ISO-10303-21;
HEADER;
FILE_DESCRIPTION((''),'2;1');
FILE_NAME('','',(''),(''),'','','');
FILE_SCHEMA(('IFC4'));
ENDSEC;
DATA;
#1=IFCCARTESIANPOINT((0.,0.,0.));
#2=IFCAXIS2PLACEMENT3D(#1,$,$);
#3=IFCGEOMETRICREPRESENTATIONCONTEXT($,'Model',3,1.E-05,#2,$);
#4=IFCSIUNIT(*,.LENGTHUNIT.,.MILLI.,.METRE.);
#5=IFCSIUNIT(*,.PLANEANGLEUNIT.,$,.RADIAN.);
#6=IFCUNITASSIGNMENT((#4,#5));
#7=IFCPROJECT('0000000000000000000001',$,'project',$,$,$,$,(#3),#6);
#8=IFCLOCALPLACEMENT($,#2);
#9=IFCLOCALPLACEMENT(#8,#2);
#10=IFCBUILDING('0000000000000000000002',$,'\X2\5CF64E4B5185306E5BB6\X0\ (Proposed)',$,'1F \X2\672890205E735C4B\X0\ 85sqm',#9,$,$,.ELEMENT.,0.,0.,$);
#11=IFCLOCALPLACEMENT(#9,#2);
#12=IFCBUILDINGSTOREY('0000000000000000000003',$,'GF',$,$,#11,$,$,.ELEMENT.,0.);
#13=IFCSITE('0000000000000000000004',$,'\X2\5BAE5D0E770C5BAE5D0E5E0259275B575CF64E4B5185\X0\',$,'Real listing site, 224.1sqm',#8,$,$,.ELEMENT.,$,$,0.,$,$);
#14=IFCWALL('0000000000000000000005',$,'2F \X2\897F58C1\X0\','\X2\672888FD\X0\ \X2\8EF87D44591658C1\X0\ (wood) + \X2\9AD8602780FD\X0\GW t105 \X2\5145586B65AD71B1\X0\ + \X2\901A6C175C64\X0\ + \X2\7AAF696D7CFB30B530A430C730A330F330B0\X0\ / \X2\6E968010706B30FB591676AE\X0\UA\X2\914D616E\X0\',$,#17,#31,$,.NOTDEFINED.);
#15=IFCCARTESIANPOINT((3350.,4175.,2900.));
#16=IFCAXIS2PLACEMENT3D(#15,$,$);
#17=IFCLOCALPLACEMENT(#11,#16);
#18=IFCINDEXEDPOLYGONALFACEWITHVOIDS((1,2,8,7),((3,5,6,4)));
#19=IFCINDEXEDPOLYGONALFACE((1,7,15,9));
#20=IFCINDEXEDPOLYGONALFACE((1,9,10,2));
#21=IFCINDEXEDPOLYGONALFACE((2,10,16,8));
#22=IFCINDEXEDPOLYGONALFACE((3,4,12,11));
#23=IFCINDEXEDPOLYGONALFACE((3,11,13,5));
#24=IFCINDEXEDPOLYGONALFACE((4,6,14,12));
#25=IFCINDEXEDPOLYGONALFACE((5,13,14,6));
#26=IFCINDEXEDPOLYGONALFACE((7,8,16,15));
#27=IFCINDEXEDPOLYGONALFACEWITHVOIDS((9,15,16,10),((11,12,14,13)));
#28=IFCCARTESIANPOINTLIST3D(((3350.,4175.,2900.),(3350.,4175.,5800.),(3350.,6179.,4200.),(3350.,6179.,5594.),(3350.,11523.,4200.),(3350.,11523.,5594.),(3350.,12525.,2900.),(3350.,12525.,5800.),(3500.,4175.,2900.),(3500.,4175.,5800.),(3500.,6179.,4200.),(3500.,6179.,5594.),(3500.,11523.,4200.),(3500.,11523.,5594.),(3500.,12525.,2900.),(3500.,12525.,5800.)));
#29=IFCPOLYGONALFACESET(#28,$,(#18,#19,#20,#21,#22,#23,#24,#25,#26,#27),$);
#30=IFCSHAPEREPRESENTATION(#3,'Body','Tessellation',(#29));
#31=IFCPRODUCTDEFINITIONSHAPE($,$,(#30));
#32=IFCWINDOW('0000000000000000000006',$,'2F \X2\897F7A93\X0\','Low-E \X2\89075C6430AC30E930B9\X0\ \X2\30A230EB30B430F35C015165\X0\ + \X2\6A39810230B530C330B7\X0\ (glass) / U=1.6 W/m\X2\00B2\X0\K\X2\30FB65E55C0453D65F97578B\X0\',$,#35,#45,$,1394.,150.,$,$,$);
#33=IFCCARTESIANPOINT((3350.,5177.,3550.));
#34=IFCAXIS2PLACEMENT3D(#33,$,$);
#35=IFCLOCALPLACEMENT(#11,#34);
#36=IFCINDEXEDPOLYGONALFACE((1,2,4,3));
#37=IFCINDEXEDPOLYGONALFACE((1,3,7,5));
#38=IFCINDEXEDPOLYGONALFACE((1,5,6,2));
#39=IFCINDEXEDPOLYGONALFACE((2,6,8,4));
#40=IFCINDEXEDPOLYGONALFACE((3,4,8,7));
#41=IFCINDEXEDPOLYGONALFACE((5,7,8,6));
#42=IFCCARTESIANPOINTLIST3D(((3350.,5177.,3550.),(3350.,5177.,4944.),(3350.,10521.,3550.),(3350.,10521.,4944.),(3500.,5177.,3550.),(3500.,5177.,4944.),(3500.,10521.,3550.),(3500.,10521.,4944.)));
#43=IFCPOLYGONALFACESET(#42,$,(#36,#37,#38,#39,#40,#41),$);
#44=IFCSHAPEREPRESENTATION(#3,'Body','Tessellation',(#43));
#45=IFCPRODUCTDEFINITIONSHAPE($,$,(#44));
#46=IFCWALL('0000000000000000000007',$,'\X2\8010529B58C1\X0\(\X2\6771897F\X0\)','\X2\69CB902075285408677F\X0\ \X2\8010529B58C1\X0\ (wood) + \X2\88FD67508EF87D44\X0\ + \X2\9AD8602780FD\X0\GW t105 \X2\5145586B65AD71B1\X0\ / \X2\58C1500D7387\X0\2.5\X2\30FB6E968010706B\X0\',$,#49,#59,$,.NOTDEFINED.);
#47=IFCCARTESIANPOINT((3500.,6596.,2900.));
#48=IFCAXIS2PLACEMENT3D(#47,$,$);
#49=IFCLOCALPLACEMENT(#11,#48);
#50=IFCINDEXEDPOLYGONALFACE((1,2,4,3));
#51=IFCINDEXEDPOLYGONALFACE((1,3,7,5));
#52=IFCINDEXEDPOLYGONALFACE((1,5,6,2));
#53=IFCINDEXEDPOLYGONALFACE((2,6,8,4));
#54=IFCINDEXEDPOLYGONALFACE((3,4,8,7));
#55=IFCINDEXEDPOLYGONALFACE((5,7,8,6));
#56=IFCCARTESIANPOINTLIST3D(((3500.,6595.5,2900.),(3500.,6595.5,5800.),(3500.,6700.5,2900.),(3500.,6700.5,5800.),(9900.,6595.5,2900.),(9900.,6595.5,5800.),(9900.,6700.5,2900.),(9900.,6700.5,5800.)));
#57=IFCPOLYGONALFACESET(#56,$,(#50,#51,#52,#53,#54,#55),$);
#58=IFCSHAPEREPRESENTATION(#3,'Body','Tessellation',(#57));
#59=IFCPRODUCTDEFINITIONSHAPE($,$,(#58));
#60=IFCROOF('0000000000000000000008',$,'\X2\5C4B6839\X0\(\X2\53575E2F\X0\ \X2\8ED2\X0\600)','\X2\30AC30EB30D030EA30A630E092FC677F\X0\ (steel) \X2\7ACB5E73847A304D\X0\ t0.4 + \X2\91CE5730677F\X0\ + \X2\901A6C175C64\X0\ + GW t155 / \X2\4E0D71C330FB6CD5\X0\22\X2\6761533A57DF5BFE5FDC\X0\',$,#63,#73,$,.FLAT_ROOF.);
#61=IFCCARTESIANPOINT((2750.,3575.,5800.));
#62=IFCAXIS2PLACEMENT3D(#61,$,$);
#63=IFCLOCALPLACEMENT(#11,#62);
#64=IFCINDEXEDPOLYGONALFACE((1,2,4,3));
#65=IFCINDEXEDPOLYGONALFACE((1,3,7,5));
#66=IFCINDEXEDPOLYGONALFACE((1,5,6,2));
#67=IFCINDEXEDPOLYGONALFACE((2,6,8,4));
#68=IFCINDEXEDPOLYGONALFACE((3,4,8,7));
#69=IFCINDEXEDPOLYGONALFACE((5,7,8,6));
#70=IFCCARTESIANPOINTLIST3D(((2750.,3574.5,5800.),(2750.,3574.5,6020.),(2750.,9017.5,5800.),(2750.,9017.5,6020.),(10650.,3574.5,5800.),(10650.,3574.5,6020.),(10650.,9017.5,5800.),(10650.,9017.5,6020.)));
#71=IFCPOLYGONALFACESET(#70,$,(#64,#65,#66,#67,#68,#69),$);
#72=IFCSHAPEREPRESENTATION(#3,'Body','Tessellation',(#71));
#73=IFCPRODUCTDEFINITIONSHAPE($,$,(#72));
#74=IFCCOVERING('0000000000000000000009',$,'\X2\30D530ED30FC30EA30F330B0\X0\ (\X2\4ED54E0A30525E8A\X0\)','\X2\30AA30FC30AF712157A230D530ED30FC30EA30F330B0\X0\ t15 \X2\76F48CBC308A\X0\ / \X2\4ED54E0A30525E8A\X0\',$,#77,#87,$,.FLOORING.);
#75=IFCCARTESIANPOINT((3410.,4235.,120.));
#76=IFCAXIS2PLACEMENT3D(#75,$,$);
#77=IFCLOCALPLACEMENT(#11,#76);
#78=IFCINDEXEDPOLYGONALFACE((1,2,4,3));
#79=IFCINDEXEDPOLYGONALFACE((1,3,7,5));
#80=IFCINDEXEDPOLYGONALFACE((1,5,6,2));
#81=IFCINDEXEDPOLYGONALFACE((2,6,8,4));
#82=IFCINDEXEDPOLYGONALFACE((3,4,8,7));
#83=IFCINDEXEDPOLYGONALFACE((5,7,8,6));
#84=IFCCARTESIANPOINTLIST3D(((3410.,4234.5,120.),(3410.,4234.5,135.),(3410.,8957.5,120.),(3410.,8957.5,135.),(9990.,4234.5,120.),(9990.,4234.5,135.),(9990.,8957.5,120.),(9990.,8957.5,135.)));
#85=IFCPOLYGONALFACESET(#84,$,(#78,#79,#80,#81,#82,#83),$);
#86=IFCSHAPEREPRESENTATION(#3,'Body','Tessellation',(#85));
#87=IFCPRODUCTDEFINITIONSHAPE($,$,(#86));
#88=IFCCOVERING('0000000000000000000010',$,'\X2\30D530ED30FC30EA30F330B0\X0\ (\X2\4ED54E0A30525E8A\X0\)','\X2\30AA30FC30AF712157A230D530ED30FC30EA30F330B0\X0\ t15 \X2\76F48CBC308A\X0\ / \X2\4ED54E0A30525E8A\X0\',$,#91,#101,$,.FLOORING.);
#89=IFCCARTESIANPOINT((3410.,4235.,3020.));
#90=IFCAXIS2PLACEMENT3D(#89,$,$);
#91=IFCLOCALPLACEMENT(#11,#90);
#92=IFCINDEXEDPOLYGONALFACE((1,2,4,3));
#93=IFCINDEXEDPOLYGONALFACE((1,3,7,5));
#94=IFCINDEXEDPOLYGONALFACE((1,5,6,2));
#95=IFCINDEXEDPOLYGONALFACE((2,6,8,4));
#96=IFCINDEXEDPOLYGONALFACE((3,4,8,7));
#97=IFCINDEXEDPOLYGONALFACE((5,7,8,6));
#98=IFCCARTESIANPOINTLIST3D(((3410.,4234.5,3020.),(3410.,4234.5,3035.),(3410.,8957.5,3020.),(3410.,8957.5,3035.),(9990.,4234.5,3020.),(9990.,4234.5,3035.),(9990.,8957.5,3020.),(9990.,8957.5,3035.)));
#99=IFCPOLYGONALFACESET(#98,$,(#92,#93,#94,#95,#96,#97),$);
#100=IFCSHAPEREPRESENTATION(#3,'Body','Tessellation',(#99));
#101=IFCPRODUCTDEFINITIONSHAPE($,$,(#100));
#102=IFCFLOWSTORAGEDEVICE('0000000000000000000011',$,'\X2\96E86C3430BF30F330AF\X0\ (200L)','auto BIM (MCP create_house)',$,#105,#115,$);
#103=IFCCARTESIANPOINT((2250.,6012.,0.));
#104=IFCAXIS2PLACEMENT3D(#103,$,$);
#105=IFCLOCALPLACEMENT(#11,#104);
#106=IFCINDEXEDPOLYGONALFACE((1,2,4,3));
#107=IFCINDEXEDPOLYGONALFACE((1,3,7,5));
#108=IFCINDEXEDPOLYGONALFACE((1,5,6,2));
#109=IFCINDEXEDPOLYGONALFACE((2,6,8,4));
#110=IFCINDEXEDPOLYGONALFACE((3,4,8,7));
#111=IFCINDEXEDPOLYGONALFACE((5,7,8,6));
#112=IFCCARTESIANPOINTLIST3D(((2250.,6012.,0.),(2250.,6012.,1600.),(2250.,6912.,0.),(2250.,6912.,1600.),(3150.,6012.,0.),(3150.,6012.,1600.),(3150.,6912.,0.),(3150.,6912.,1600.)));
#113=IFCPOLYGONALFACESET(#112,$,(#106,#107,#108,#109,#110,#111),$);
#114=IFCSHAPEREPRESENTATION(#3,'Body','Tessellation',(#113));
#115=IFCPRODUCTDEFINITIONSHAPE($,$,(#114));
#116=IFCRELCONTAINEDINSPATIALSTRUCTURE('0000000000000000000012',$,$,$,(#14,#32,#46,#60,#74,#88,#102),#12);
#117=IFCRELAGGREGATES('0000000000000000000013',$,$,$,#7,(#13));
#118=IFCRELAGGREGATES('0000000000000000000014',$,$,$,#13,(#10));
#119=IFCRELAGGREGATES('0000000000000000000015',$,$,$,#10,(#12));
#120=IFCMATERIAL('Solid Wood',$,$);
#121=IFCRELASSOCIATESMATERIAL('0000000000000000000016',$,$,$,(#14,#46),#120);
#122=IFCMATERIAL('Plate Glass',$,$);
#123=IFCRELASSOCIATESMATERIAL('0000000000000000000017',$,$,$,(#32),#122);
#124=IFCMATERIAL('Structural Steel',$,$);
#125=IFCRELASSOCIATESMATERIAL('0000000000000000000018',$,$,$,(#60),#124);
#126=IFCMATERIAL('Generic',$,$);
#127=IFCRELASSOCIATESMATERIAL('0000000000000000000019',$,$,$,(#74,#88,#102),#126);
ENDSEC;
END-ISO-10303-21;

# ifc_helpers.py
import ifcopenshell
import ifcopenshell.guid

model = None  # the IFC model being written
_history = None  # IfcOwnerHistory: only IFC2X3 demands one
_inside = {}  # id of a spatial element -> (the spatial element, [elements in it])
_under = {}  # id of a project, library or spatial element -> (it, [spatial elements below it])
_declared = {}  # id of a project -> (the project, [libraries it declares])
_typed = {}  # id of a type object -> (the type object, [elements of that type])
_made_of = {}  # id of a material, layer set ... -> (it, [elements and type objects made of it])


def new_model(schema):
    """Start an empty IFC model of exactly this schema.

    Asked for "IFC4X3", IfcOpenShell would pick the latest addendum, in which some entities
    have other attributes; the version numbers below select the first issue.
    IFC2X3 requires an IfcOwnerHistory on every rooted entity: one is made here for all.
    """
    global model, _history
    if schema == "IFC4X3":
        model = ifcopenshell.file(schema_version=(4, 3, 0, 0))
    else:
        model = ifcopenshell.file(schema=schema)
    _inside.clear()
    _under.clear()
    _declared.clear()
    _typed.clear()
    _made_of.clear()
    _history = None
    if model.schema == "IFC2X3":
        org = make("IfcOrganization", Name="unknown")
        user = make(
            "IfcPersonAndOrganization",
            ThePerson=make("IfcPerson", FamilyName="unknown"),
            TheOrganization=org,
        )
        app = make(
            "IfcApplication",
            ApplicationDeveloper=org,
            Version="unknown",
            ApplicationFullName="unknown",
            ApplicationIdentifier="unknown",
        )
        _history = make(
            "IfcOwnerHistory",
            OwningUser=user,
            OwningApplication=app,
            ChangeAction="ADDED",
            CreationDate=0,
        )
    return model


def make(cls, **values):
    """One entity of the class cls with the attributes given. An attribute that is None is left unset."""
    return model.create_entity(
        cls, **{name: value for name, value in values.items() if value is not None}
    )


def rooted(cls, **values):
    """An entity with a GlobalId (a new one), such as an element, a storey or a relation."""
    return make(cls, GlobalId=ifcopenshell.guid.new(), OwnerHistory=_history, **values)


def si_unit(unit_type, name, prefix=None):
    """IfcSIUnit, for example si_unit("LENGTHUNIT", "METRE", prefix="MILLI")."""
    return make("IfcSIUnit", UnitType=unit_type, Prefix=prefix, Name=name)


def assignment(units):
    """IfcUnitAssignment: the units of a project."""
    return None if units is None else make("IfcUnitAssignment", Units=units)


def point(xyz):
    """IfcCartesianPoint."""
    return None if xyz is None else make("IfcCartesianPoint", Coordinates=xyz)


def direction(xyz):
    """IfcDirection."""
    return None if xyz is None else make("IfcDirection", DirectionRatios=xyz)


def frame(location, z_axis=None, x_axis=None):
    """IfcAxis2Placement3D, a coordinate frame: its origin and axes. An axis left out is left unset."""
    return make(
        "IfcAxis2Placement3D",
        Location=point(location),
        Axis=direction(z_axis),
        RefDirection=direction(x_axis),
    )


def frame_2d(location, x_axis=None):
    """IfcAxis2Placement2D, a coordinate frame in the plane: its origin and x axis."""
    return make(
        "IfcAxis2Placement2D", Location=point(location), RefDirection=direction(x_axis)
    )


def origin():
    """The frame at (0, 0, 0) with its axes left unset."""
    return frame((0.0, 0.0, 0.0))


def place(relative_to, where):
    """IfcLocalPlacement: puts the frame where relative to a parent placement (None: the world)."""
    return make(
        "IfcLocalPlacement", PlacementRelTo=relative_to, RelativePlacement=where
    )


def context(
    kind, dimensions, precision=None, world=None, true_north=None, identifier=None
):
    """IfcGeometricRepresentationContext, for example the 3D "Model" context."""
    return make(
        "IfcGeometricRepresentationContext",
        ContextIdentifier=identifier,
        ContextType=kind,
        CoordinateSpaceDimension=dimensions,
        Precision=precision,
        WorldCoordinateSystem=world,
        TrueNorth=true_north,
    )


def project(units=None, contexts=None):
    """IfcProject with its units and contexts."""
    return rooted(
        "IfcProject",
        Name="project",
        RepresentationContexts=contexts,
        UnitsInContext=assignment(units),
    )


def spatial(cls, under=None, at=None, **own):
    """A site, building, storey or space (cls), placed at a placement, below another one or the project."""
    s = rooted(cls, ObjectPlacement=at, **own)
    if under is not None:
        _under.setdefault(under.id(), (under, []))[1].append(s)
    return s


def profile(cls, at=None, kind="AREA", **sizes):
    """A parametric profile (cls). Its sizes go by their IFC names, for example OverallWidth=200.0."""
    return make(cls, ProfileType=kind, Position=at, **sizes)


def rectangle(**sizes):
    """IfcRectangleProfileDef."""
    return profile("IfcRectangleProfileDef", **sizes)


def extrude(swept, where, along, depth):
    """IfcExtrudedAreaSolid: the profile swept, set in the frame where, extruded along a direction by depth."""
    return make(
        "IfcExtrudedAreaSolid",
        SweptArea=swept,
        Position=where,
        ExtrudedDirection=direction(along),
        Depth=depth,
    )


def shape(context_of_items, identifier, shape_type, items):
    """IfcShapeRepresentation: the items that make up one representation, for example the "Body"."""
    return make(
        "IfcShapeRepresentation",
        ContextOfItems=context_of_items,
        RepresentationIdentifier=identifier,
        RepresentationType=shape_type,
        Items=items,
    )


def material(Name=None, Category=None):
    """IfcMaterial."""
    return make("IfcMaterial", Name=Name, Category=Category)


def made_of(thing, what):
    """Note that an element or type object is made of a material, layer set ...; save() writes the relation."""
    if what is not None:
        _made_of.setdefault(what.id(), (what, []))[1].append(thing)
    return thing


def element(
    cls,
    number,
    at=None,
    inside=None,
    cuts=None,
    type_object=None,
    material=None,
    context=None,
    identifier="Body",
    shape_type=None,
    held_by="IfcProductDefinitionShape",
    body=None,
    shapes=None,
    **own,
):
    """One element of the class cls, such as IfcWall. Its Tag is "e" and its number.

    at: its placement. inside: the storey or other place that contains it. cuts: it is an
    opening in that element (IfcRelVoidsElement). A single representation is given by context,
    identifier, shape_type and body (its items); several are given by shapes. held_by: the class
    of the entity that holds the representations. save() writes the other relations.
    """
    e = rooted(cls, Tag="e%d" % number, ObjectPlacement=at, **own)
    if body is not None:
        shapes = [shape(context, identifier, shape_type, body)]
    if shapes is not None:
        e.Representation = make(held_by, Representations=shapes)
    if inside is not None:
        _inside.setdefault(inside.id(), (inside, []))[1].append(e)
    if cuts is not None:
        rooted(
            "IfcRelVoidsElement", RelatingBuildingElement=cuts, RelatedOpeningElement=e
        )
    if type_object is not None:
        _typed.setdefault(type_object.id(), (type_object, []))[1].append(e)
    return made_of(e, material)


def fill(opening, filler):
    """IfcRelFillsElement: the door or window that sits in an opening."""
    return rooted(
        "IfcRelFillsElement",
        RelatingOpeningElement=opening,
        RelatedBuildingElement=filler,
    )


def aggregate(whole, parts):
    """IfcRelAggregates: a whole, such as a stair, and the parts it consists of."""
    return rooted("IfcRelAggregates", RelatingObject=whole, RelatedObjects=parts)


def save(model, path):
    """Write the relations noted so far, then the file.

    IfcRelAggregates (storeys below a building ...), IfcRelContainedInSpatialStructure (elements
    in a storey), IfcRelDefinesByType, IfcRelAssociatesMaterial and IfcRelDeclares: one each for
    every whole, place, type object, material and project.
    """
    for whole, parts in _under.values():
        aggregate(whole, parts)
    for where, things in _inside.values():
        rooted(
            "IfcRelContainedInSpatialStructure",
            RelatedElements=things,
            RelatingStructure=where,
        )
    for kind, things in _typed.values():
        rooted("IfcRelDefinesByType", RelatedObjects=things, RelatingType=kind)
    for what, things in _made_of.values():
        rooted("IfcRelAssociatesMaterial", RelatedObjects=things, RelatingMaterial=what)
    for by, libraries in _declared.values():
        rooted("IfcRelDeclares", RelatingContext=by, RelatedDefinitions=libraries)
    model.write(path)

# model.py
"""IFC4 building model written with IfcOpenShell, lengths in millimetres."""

from ifc_helpers import new_model, si_unit, frame, frame_2d, origin, place, context, project, spatial, rectangle, extrude, material, element, fill, save


model = new_model("IFC4")

# Units and contexts
model_context = context("Model", 3, precision=1e-05, world=origin())
ifc_project = project(units=[si_unit("LENGTHUNIT", "METRE", prefix="MILLI"), si_unit("PLANEANGLEUNIT", "RADIAN")], contexts=[model_context])

# Site, building, storey
site_placement = place(None, origin())
site = spatial("IfcSite", under=ifc_project, at=site_placement, Name="宮崎県宮崎市大字島之内", ObjectType="Real listing site, 224.1sqm", CompositionType="ELEMENT", RefElevation=0.0)
building_placement = place(site_placement, origin())
building = spatial("IfcBuilding", under=site, at=building_placement, Name="島之内の家 (Proposed)", ObjectType="1F 木造平屋 85sqm", CompositionType="ELEMENT", ElevationOfRefHeight=0.0, ElevationOfTerrain=0.0)
storey_placement = place(building_placement, origin())
storey = spatial("IfcBuildingStorey", under=building, at=storey_placement, Name="GF", CompositionType="ELEMENT", Elevation=0.0)

# Shared definitions
ifc_material_1 = material(Name="Solid Wood")
ifc_material_2 = material(Name="Generic")

# Shared definitions
ifc_material_3 = material(Name="Plate Glass")

# Wall, opening, window
wall_1_placement = place(storey_placement, frame((3350.0, 4175.0, 2900.0)))
wall_1 = element("IfcWall", 1, at=wall_1_placement, inside=storey, material=ifc_material_1, Name="2F 西壁", Description="木製 軸組外壁 (wood) + 高性能GW t105 充填断熱 + 通気層 + 窯業系サイディング / 準耐火・外皮UA配慮", PredefinedType="NOTDEFINED", context=model_context, shape_type="SweptSolid", body=[
    extrude(rectangle(XDim=150.0, YDim=8350.0, at=frame_2d((75.0, 4175.0))), frame((3350.0, 4175.0, 2900.0)), (0.0, 0.0, 1.0), 2900.0),
])
opening_1_placement = place(storey_placement, frame((3350.0, 5177.0, 3550.0)))
opening_1 = element("IfcOpeningElement", 2, at=opening_1_placement, cuts=wall_1, PredefinedType="NOTDEFINED", context=model_context, shape_type="SweptSolid", body=[
    extrude(rectangle(XDim=150.0, YDim=5344.0, at=frame_2d((75.0, 2672.0))), frame((3350.0, 5177.0, 3550.0)), (0.0, 0.0, 1.0), 1394.0),
])
window_1_placement = place(storey_placement, frame((3350.0, 5177.0, 3550.0)))
window_1 = element("IfcWindow", 3, at=window_1_placement, inside=storey, material=ifc_material_3, Name="2F 西窓", Description="Low-E 複層ガラス アルゴン封入 + 樹脂サッシ (glass) / U=1.6 W/m²K・日射取得型", OverallHeight=1394.0, OverallWidth=150.0, context=model_context, shape_type="SweptSolid", body=[
    extrude(rectangle(XDim=150.0, YDim=5344.0, at=frame_2d((75.0, 2672.0))), frame((3350.0, 5177.0, 3550.0)), (0.0, 0.0, 1.0), 1394.0),
])
fill(opening_1, window_1)

# Wall
wall_2_placement = place(storey_placement, frame((3500.0, 6596.0, 2900.0)))
element("IfcWall", 4, at=wall_2_placement, inside=storey, material=ifc_material_1, Name="耐力壁(東西)", Description="構造用合板 耐力壁 (wood) + 製材軸組 + 高性能GW t105 充填断熱 / 壁倍率2.5・準耐火", PredefinedType="NOTDEFINED", context=model_context, shape_type="SweptSolid", body=[
    extrude(rectangle(XDim=6400.0, YDim=105.0, at=frame_2d((3200.0, 52.0))), frame((3500.0, 6596.0, 2900.0)), (0.0, 0.0, 1.0), 2900.0),
])

# Roof
ifc_material_4 = material(Name="Structural Steel")
for number, where, name in (
    (5, (2750.0, 3575.0, 5800.0), "屋根(南帯 軒600)"),
):
    element("IfcRoof", number, at=place(storey_placement, frame(where)), inside=storey, material=ifc_material_4, Name=name, Description="ガルバリウム鋼板 (steel) 立平葺き t0.4 + 野地板 + 通気層 + GW t155 / 不燃・法22条区域対応", PredefinedType="FLAT_ROOF", context=model_context, shape_type="SweptSolid", body=[
        extrude(rectangle(XDim=7900.0, YDim=5443.0, at=frame_2d((3950.0, 2721.0))), frame((2750.0, 3575.0, 5800.0)), (0.0, 0.0, 1.0), 220.0),
    ])

# Coverings
covering_1_placement = place(storey_placement, frame((3410.0, 4235.0, 120.0)))
element("IfcCovering", 6, at=covering_1_placement, inside=storey, material=ifc_material_2, Name="フローリング (仕上げ床)", Description="オーク無垢フローリング t15 直貼り / 仕上げ床", PredefinedType="FLOORING", context=model_context, shape_type="SweptSolid", body=[
    extrude(rectangle(XDim=6580.0, YDim=4723.0, at=frame_2d((3290.0, 2361.0))), frame((3410.0, 4235.0, 120.0)), (0.0, 0.0, 1.0), 15.0),
])
covering_2_placement = place(storey_placement, frame((3410.0, 4235.0, 3020.0)))
element("IfcCovering", 7, at=covering_2_placement, inside=storey, material=ifc_material_2, Name="フローリング (仕上げ床)", Description="オーク無垢フローリング t15 直貼り / 仕上げ床", PredefinedType="FLOORING", context=model_context, shape_type="SweptSolid", body=[
    extrude(rectangle(XDim=6580.0, YDim=4723.0, at=frame_2d((3290.0, 2361.0))), frame((3410.0, 4235.0, 3020.0)), (0.0, 0.0, 1.0), 15.0),
])

# Flow storage device
flow_storage_device_placement = place(storey_placement, frame((2250.0, 6012.0, 0.0)))
element("IfcFlowStorageDevice", 8, at=flow_storage_device_placement, inside=storey, material=ifc_material_2, Name="雨水タンク (200L)", Description="auto BIM (MCP create_house)", context=model_context, shape_type="SweptSolid", body=[
    extrude(rectangle(XDim=900.0, YDim=900.0, at=frame_2d((450.0, 450.0))), frame((2250.0, 6012.0, 0.0)), (0.0, 0.0, 1.0), 1600.0),
])

save(model, "model.ifc")
